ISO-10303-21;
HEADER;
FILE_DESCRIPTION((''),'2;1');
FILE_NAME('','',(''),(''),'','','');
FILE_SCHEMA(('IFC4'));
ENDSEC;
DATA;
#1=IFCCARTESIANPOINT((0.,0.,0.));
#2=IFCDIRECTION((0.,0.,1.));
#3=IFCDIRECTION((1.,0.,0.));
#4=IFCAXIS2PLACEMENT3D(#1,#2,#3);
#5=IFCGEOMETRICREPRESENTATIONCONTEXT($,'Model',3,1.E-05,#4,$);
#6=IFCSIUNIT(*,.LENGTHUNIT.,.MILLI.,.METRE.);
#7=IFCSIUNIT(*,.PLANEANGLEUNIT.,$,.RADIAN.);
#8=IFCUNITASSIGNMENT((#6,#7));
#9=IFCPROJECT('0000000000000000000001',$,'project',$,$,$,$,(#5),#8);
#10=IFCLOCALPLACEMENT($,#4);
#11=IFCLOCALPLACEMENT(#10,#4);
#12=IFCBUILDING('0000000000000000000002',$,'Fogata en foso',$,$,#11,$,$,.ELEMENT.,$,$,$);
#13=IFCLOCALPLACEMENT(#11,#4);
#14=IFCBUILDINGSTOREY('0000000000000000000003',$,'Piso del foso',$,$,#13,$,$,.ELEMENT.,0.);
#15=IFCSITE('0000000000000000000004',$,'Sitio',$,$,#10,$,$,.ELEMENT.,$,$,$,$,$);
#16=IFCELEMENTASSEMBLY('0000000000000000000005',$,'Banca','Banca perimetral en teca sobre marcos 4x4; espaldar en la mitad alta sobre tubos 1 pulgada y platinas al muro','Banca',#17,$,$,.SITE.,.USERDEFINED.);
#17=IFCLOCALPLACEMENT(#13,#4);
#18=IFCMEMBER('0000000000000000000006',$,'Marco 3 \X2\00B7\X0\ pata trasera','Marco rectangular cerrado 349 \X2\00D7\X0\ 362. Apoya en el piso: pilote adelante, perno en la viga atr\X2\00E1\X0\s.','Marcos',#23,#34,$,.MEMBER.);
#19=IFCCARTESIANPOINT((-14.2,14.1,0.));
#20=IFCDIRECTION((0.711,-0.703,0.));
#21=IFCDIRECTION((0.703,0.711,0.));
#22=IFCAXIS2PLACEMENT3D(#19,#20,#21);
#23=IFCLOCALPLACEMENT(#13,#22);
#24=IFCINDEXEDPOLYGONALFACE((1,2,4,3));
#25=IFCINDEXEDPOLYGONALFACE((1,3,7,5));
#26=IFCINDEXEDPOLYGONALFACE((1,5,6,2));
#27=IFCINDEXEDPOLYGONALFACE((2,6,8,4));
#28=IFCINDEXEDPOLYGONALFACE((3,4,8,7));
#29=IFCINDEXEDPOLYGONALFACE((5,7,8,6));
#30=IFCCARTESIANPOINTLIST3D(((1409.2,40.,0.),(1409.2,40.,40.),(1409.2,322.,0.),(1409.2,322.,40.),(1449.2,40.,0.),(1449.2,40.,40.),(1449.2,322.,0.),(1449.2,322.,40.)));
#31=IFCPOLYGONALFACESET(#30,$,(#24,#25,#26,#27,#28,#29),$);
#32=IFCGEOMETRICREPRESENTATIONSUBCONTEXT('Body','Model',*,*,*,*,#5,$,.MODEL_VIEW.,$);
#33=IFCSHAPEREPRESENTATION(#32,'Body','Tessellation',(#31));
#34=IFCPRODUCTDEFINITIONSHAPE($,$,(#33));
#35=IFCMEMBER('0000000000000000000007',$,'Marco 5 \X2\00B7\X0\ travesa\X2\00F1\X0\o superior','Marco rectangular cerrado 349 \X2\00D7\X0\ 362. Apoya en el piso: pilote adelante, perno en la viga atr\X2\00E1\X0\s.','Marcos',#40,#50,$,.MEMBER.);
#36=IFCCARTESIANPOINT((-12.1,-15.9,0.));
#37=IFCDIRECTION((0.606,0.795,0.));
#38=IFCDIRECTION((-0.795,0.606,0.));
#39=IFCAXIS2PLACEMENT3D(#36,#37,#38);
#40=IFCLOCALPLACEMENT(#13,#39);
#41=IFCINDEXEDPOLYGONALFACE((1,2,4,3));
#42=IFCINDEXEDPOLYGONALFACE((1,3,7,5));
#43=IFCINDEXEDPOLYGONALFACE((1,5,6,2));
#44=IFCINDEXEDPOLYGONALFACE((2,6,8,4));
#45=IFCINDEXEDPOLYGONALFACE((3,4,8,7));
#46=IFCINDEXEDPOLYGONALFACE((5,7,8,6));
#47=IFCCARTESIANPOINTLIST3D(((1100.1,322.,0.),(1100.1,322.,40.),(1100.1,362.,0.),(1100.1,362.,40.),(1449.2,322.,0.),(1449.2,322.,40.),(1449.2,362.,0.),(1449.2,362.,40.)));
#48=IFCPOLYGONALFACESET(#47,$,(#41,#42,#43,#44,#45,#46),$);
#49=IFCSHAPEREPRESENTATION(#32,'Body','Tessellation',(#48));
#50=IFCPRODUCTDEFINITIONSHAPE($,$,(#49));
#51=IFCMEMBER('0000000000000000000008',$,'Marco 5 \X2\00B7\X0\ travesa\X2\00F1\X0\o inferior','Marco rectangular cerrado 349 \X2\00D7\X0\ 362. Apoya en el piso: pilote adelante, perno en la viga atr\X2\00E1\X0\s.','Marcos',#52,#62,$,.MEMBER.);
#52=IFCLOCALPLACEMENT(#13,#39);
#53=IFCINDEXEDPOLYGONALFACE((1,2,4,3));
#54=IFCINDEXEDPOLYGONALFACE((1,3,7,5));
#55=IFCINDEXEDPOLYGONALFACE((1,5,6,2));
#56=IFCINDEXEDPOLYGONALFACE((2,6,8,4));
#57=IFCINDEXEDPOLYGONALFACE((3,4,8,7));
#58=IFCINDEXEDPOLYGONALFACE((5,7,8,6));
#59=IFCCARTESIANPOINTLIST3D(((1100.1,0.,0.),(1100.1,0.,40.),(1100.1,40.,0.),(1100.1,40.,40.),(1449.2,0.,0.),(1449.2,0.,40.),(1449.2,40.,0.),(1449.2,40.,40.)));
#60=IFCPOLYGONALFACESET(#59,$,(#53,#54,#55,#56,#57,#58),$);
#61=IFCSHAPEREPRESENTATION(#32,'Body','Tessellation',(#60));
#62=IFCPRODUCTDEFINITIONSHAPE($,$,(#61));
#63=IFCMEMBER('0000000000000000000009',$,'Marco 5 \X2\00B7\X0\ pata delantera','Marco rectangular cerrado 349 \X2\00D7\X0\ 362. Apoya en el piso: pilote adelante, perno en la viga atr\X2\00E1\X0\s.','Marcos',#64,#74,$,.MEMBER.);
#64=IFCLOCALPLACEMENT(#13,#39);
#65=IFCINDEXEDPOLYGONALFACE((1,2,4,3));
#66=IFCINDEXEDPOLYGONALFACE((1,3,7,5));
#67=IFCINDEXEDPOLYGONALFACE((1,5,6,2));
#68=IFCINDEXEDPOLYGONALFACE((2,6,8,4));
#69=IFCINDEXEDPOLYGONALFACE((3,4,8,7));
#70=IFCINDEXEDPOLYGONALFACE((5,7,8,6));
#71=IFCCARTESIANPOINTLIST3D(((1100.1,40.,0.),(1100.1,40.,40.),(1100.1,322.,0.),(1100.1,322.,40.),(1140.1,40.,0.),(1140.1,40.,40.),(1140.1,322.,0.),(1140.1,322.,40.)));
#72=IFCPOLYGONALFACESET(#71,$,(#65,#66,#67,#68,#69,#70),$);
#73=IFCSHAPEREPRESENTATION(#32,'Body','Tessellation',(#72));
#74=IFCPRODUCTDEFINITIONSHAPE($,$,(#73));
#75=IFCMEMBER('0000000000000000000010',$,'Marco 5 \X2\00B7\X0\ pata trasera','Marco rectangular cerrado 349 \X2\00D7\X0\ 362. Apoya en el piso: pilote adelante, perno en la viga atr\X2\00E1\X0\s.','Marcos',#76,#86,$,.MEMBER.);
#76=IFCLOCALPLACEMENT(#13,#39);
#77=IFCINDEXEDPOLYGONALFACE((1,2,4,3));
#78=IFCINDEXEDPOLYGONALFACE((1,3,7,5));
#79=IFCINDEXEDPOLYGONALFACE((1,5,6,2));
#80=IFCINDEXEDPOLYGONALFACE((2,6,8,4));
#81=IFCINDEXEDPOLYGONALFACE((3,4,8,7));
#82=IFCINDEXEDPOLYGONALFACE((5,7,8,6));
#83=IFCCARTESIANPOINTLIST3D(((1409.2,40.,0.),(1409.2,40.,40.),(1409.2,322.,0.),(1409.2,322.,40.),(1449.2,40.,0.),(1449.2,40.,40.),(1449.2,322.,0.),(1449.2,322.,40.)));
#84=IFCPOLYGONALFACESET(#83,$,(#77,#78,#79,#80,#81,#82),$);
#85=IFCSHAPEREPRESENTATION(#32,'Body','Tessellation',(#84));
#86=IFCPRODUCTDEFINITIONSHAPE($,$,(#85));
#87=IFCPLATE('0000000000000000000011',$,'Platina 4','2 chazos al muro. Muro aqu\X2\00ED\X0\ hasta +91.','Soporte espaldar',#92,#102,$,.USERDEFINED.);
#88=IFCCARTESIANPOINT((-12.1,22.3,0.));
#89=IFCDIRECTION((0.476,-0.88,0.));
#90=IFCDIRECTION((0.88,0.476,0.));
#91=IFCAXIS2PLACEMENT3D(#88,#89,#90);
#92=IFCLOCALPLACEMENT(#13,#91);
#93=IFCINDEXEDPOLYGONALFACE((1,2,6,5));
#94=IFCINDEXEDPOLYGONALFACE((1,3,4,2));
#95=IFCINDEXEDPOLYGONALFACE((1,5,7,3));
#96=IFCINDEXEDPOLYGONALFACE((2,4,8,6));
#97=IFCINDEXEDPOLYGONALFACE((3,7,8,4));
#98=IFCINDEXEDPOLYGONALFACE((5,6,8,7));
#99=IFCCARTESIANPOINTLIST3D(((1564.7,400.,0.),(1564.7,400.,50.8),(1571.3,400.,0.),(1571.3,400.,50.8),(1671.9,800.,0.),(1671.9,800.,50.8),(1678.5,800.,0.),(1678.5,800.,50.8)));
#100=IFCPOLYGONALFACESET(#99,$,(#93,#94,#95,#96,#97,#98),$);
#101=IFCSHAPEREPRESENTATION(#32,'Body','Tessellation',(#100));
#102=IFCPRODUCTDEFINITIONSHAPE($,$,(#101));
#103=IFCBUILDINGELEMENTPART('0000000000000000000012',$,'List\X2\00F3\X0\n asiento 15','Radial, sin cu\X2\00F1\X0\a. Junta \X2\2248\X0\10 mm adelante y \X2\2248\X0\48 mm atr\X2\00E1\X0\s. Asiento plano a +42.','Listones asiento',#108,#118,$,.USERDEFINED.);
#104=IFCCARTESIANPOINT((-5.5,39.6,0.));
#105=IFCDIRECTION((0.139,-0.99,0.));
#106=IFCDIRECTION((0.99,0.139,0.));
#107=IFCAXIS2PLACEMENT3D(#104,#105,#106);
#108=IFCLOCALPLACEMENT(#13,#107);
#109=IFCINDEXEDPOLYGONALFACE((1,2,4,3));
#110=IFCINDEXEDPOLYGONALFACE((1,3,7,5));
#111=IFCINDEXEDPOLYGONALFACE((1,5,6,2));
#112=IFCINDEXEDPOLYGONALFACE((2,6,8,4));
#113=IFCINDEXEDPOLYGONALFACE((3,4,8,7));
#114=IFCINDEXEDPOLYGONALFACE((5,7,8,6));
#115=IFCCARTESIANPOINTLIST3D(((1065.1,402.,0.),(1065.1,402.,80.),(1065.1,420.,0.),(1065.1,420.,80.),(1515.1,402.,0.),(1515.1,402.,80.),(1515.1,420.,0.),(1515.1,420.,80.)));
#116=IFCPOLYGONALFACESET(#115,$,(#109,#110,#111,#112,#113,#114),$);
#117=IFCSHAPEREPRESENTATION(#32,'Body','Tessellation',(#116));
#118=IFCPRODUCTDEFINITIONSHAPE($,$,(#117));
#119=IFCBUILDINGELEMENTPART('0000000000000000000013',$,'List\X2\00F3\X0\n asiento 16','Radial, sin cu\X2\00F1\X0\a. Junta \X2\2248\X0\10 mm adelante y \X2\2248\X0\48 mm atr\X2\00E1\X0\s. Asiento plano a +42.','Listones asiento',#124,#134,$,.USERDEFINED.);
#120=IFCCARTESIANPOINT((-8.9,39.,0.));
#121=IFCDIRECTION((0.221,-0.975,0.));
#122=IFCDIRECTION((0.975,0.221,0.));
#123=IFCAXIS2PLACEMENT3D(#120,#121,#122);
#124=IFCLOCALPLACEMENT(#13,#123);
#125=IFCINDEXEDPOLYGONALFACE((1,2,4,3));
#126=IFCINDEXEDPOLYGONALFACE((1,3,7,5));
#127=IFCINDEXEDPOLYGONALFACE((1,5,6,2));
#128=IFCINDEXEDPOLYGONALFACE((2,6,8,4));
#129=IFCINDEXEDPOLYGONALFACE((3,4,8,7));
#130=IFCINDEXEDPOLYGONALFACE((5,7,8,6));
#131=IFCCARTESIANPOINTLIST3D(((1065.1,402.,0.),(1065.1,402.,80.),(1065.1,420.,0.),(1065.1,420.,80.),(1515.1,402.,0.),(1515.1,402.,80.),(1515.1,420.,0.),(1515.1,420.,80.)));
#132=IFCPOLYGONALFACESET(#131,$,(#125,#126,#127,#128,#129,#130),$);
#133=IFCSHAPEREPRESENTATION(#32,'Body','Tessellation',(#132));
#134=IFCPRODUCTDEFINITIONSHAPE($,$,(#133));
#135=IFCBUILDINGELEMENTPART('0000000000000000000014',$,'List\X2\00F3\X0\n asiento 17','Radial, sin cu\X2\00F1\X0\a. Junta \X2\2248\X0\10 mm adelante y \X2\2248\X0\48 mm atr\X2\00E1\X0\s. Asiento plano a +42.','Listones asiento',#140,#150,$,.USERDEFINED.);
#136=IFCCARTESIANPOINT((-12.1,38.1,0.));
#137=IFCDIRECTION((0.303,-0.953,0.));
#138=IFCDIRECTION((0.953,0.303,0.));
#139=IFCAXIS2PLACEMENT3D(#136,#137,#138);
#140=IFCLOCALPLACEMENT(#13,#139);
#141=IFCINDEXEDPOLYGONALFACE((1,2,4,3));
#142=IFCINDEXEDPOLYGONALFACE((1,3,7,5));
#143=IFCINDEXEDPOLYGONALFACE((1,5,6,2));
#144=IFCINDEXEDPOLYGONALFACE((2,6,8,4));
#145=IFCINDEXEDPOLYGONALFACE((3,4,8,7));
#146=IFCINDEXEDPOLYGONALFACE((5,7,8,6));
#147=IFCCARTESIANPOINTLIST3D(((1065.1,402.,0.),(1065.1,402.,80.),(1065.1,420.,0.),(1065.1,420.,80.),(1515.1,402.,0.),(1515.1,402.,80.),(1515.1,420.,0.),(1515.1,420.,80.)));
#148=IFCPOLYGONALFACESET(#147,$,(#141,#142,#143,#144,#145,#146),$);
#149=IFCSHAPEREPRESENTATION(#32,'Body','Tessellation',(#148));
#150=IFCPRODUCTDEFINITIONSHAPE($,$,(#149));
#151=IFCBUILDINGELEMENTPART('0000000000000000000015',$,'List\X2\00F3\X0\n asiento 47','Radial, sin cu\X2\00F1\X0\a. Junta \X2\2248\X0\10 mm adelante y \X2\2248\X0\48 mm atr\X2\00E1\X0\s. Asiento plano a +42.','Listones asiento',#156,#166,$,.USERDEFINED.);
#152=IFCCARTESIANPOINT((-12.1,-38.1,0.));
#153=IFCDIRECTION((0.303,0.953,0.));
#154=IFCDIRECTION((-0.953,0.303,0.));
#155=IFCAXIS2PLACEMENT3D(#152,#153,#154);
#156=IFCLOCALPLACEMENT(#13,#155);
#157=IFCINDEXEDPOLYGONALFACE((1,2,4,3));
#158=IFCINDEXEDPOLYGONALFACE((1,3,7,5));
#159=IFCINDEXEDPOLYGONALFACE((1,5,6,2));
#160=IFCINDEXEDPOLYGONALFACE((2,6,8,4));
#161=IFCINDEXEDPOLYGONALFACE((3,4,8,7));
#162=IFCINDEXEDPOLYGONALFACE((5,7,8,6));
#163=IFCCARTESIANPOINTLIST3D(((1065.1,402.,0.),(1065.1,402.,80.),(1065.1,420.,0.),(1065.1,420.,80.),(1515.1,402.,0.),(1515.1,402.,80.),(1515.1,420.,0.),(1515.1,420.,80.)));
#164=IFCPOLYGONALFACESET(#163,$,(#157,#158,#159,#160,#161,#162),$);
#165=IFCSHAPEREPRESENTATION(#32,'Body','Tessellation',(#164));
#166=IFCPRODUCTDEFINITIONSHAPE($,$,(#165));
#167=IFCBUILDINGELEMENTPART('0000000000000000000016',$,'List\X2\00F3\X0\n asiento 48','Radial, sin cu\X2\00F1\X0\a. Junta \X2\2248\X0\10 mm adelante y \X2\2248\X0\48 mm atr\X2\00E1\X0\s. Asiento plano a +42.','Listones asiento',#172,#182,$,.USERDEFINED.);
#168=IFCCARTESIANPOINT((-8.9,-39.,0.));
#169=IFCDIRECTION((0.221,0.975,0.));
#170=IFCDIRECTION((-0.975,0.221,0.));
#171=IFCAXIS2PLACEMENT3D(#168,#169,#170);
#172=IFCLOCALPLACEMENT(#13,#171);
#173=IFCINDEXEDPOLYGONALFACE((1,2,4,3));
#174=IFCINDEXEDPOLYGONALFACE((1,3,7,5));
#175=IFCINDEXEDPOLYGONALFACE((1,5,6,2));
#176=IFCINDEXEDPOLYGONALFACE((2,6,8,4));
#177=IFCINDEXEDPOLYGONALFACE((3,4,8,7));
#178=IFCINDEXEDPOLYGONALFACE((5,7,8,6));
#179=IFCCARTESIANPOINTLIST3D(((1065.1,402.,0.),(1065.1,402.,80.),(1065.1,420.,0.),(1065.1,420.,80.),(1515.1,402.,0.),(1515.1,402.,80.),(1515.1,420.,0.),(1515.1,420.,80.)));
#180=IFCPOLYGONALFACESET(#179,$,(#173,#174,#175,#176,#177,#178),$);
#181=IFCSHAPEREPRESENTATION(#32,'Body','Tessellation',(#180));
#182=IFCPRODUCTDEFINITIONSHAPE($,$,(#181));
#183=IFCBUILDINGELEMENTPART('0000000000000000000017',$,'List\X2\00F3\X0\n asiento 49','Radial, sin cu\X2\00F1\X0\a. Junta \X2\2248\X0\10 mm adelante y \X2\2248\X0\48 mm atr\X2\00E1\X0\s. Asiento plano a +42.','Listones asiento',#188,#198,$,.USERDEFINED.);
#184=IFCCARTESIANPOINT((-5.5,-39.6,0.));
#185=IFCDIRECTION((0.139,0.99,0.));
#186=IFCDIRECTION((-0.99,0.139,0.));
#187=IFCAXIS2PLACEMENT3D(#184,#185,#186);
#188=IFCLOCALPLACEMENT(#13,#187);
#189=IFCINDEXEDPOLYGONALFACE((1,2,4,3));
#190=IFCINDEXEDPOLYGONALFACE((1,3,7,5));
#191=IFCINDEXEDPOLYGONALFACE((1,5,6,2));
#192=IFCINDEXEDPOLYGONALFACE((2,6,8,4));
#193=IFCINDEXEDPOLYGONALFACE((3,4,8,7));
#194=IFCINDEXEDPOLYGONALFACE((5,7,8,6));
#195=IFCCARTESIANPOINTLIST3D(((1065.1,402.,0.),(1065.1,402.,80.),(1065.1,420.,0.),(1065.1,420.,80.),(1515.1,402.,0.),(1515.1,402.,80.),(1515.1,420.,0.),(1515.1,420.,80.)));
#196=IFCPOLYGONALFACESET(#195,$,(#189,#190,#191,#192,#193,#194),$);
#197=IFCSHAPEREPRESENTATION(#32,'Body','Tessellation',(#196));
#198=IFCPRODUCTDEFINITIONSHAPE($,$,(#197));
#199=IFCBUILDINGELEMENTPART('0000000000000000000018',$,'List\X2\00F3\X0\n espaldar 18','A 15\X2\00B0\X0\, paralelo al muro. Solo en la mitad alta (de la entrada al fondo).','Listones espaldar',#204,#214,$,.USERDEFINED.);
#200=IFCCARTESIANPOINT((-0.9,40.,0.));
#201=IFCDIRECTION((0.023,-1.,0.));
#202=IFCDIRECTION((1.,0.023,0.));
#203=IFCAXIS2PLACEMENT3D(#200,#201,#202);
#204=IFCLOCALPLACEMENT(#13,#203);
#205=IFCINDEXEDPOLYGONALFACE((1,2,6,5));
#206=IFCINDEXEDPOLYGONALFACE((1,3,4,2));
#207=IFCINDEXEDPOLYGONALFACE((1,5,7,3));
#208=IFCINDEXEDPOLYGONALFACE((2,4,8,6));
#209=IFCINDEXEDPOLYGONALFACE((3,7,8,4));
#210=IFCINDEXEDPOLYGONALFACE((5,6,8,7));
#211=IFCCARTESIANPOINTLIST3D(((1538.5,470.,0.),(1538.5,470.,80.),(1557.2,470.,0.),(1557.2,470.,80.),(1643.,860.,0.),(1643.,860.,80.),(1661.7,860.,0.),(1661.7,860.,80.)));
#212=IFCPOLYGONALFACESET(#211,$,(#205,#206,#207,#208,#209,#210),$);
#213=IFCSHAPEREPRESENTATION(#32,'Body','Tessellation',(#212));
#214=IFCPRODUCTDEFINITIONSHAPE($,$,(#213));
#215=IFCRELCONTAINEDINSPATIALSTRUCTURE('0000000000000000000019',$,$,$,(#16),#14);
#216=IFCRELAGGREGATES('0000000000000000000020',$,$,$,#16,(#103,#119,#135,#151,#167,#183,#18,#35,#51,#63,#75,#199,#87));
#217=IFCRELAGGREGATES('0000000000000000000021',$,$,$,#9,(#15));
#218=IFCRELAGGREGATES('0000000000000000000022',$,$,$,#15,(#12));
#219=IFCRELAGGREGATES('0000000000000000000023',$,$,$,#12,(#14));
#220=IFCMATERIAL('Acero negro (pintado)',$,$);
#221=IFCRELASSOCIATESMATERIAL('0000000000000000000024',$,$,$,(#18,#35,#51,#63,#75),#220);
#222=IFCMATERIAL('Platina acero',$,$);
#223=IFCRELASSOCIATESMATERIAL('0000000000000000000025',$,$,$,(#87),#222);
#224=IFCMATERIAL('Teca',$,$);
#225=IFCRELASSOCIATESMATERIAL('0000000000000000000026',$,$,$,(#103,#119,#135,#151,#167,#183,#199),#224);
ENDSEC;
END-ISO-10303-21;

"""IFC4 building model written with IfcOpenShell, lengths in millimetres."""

from ifc_helpers import new_model, si_unit, frame, origin_with_axes, place, context, subcontext, project, spatial, polyline, outline, extrude, material, element, aggregate, save


model = new_model("IFC4")

# Units and contexts
model_context = context("Model", 3, precision=1e-05, world=origin_with_axes())
body_context = subcontext(model_context, "Body", "Model", "MODEL_VIEW")
ifc_project = project(units=[si_unit("LENGTHUNIT", "METRE", prefix="MILLI"), si_unit("PLANEANGLEUNIT", "RADIAN")], contexts=[model_context])

# Site, building, storey
site_placement = place(None, origin_with_axes())
site = spatial("IfcSite", under=ifc_project, at=site_placement, Name="Sitio", CompositionType="ELEMENT")
building_placement = place(site_placement, origin_with_axes())
building = spatial("IfcBuilding", under=site, at=building_placement, Name="Fogata en foso", CompositionType="ELEMENT")
storey_placement = place(building_placement, origin_with_axes())
storey = spatial("IfcBuildingStorey", under=building, at=storey_placement, Name="Piso del foso", CompositionType="ELEMENT", Elevation=0.0)

# Element assembly, members, plate, building element parts
assembly_1_placement = place(storey_placement, origin_with_axes())
assembly_1 = element("IfcElementAssembly", 1, at=assembly_1_placement, inside=storey, Name="Banca", Description="Banca perimetral en teca sobre marcos 4x4; espaldar en la mitad alta sobre tubos 1 pulgada y platinas al muro", ObjectType="Banca", AssemblyPlace="SITE", PredefinedType="USERDEFINED")
ifc_material_1 = material(Name="Acero negro (pintado)")
member_1_placement = place(storey_placement, frame((-14.2, 14.1, 0.0), z_axis=(0.711, -0.703, 0.0), x_axis=(0.703, 0.711, 0.0)))
member_1 = element("IfcMember", 2, at=member_1_placement, material=ifc_material_1, Name="Marco 3 · pata trasera", Description="Marco rectangular cerrado 349 × 362. Apoya en el piso: pilote adelante, perno en la viga atrás.", ObjectType="Marcos", PredefinedType="MEMBER", context=body_context, shape_type="SweptSolid", body=[
    extrude(outline(polyline([(1409.2, 40.0), (1449.2, 40.0), (1449.2, 322.0), (1409.2, 322.0), (1409.2, 40.0)])), origin_with_axes(), (0.0, 0.0, 1.0), 40.0),
])
member_2_placement = place(storey_placement, frame((-12.1, -15.9, 0.0), z_axis=(0.606, 0.795, 0.0), x_axis=(-0.795, 0.606, 0.0)))
member_2 = element("IfcMember", 3, at=member_2_placement, material=ifc_material_1, Name="Marco 5 · travesaño superior", Description="Marco rectangular cerrado 349 × 362. Apoya en el piso: pilote adelante, perno en la viga atrás.", ObjectType="Marcos", PredefinedType="MEMBER", context=body_context, shape_type="SweptSolid", body=[
    extrude(outline(polyline([(1100.1, 322.0), (1449.2, 322.0), (1449.2, 362.0), (1100.1, 362.0), (1100.1, 322.0)])), origin_with_axes(), (0.0, 0.0, 1.0), 40.0),
])
member_3_placement = place(storey_placement, frame((-12.1, -15.9, 0.0), z_axis=(0.606, 0.795, 0.0), x_axis=(-0.795, 0.606, 0.0)))
member_3 = element("IfcMember", 4, at=member_3_placement, material=ifc_material_1, Name="Marco 5 · travesaño inferior", Description="Marco rectangular cerrado 349 × 362. Apoya en el piso: pilote adelante, perno en la viga atrás.", ObjectType="Marcos", PredefinedType="MEMBER", context=body_context, shape_type="SweptSolid", body=[
    extrude(outline(polyline([(1100.1, 0.0), (1449.2, 0.0), (1449.2, 40.0), (1100.1, 40.0), (1100.1, 0.0)])), origin_with_axes(), (0.0, 0.0, 1.0), 40.0),
])
member_4_placement = place(storey_placement, frame((-12.1, -15.9, 0.0), z_axis=(0.606, 0.795, 0.0), x_axis=(-0.795, 0.606, 0.0)))
member_4 = element("IfcMember", 5, at=member_4_placement, material=ifc_material_1, Name="Marco 5 · pata delantera", Description="Marco rectangular cerrado 349 × 362. Apoya en el piso: pilote adelante, perno en la viga atrás.", ObjectType="Marcos", PredefinedType="MEMBER", context=body_context, shape_type="SweptSolid", body=[
    extrude(outline(polyline([(1100.1, 40.0), (1140.1, 40.0), (1140.1, 322.0), (1100.1, 322.0), (1100.1, 40.0)])), origin_with_axes(), (0.0, 0.0, 1.0), 40.0),
])
member_5_placement = place(storey_placement, frame((-12.1, -15.9, 0.0), z_axis=(0.606, 0.795, 0.0), x_axis=(-0.795, 0.606, 0.0)))
member_5 = element("IfcMember", 6, at=member_5_placement, material=ifc_material_1, Name="Marco 5 · pata trasera", Description="Marco rectangular cerrado 349 × 362. Apoya en el piso: pilote adelante, perno en la viga atrás.", ObjectType="Marcos", PredefinedType="MEMBER", context=body_context, shape_type="SweptSolid", body=[
    extrude(outline(polyline([(1409.2, 40.0), (1449.2, 40.0), (1449.2, 322.0), (1409.2, 322.0), (1409.2, 40.0)])), origin_with_axes(), (0.0, 0.0, 1.0), 40.0),
])
ifc_material_2 = material(Name="Platina acero")
plate_placement = place(storey_placement, frame((-12.1, 22.3, 0.0), z_axis=(0.476, -0.88, 0.0), x_axis=(0.88, 0.476, 0.0)))
plate = element("IfcPlate", 7, at=plate_placement, material=ifc_material_2, Name="Platina 4", Description="2 chazos al muro. Muro aquí hasta +91.", ObjectType="Soporte espaldar", PredefinedType="USERDEFINED", context=body_context, shape_type="SweptSolid", body=[
    extrude(outline(polyline([(1564.7, 400.0), (1571.3, 400.0), (1678.5, 800.0), (1671.9, 800.0), (1564.7, 400.0)])), origin_with_axes(), (0.0, 0.0, 1.0), 50.8),
])
ifc_material_3 = material(Name="Teca")
building_element_part_1_placement = place(storey_placement, frame((-5.5, 39.6, 0.0), z_axis=(0.139, -0.99, 0.0), x_axis=(0.99, 0.139, 0.0)))
building_element_part_1 = element("IfcBuildingElementPart", 8, at=building_element_part_1_placement, material=ifc_material_3, Name="Listón asiento 15", Description="Radial, sin cuña. Junta ≈10 mm adelante y ≈48 mm atrás. Asiento plano a +42.", ObjectType="Listones asiento", PredefinedType="USERDEFINED", context=body_context, shape_type="SweptSolid", body=[
    extrude(outline(polyline([(1065.1, 402.0), (1515.1, 402.0), (1515.1, 420.0), (1065.1, 420.0), (1065.1, 402.0)])), origin_with_axes(), (0.0, 0.0, 1.0), 80.0),
])
building_element_part_2_placement = place(storey_placement, frame((-8.9, 39.0, 0.0), z_axis=(0.221, -0.975, 0.0), x_axis=(0.975, 0.221, 0.0)))
building_element_part_2 = element("IfcBuildingElementPart", 9, at=building_element_part_2_placement, material=ifc_material_3, Name="Listón asiento 16", Description="Radial, sin cuña. Junta ≈10 mm adelante y ≈48 mm atrás. Asiento plano a +42.", ObjectType="Listones asiento", PredefinedType="USERDEFINED", context=body_context, shape_type="SweptSolid", body=[
    extrude(outline(polyline([(1065.1, 402.0), (1515.1, 402.0), (1515.1, 420.0), (1065.1, 420.0), (1065.1, 402.0)])), origin_with_axes(), (0.0, 0.0, 1.0), 80.0),
])
building_element_part_3_placement = place(storey_placement, frame((-12.1, 38.1, 0.0), z_axis=(0.303, -0.953, 0.0), x_axis=(0.953, 0.303, 0.0)))
building_element_part_3 = element("IfcBuildingElementPart", 10, at=building_element_part_3_placement, material=ifc_material_3, Name="Listón asiento 17", Description="Radial, sin cuña. Junta ≈10 mm adelante y ≈48 mm atrás. Asiento plano a +42.", ObjectType="Listones asiento", PredefinedType="USERDEFINED", context=body_context, shape_type="SweptSolid", body=[
    extrude(outline(polyline([(1065.1, 402.0), (1515.1, 402.0), (1515.1, 420.0), (1065.1, 420.0), (1065.1, 402.0)])), origin_with_axes(), (0.0, 0.0, 1.0), 80.0),
])
building_element_part_4_placement = place(storey_placement, frame((-12.1, -38.1, 0.0), z_axis=(0.303, 0.953, 0.0), x_axis=(-0.953, 0.303, 0.0)))
building_element_part_4 = element("IfcBuildingElementPart", 11, at=building_element_part_4_placement, material=ifc_material_3, Name="Listón asiento 47", Description="Radial, sin cuña. Junta ≈10 mm adelante y ≈48 mm atrás. Asiento plano a +42.", ObjectType="Listones asiento", PredefinedType="USERDEFINED", context=body_context, shape_type="SweptSolid", body=[
    extrude(outline(polyline([(1065.1, 402.0), (1515.1, 402.0), (1515.1, 420.0), (1065.1, 420.0), (1065.1, 402.0)])), origin_with_axes(), (0.0, 0.0, 1.0), 80.0),
])
building_element_part_5_placement = place(storey_placement, frame((-8.9, -39.0, 0.0), z_axis=(0.221, 0.975, 0.0), x_axis=(-0.975, 0.221, 0.0)))
building_element_part_5 = element("IfcBuildingElementPart", 12, at=building_element_part_5_placement, material=ifc_material_3, Name="Listón asiento 48", Description="Radial, sin cuña. Junta ≈10 mm adelante y ≈48 mm atrás. Asiento plano a +42.", ObjectType="Listones asiento", PredefinedType="USERDEFINED", context=body_context, shape_type="SweptSolid", body=[
    extrude(outline(polyline([(1065.1, 402.0), (1515.1, 402.0), (1515.1, 420.0), (1065.1, 420.0), (1065.1, 402.0)])), origin_with_axes(), (0.0, 0.0, 1.0), 80.0),
])
building_element_part_6_placement = place(storey_placement, frame((-5.5, -39.6, 0.0), z_axis=(0.139, 0.99, 0.0), x_axis=(-0.99, 0.139, 0.0)))
building_element_part_6 = element("IfcBuildingElementPart", 13, at=building_element_part_6_placement, material=ifc_material_3, Name="Listón asiento 49", Description="Radial, sin cuña. Junta ≈10 mm adelante y ≈48 mm atrás. Asiento plano a +42.", ObjectType="Listones asiento", PredefinedType="USERDEFINED", context=body_context, shape_type="SweptSolid", body=[
    extrude(outline(polyline([(1065.1, 402.0), (1515.1, 402.0), (1515.1, 420.0), (1065.1, 420.0), (1065.1, 402.0)])), origin_with_axes(), (0.0, 0.0, 1.0), 80.0),
])
building_element_part_7_placement = place(storey_placement, frame((-0.9, 40.0, 0.0), z_axis=(0.023, -1.0, 0.0), x_axis=(1.0, 0.023, 0.0)))
building_element_part_7 = element("IfcBuildingElementPart", 14, at=building_element_part_7_placement, material=ifc_material_3, Name="Listón espaldar 18", Description="A 15°, paralelo al muro. Solo en la mitad alta (de la entrada al fondo).", ObjectType="Listones espaldar", PredefinedType="USERDEFINED", context=body_context, shape_type="SweptSolid", body=[
    extrude(outline(polyline([(1538.5, 470.0), (1557.2, 470.0), (1661.7, 860.0), (1643.0, 860.0), (1538.5, 470.0)])), origin_with_axes(), (0.0, 0.0, 1.0), 80.0),
])
aggregate(assembly_1, [building_element_part_1, building_element_part_2, building_element_part_3, building_element_part_4, building_element_part_5, building_element_part_6, member_1, member_2, member_3, member_4, member_5, building_element_part_7, plate])

save(model, "model.ifc")
